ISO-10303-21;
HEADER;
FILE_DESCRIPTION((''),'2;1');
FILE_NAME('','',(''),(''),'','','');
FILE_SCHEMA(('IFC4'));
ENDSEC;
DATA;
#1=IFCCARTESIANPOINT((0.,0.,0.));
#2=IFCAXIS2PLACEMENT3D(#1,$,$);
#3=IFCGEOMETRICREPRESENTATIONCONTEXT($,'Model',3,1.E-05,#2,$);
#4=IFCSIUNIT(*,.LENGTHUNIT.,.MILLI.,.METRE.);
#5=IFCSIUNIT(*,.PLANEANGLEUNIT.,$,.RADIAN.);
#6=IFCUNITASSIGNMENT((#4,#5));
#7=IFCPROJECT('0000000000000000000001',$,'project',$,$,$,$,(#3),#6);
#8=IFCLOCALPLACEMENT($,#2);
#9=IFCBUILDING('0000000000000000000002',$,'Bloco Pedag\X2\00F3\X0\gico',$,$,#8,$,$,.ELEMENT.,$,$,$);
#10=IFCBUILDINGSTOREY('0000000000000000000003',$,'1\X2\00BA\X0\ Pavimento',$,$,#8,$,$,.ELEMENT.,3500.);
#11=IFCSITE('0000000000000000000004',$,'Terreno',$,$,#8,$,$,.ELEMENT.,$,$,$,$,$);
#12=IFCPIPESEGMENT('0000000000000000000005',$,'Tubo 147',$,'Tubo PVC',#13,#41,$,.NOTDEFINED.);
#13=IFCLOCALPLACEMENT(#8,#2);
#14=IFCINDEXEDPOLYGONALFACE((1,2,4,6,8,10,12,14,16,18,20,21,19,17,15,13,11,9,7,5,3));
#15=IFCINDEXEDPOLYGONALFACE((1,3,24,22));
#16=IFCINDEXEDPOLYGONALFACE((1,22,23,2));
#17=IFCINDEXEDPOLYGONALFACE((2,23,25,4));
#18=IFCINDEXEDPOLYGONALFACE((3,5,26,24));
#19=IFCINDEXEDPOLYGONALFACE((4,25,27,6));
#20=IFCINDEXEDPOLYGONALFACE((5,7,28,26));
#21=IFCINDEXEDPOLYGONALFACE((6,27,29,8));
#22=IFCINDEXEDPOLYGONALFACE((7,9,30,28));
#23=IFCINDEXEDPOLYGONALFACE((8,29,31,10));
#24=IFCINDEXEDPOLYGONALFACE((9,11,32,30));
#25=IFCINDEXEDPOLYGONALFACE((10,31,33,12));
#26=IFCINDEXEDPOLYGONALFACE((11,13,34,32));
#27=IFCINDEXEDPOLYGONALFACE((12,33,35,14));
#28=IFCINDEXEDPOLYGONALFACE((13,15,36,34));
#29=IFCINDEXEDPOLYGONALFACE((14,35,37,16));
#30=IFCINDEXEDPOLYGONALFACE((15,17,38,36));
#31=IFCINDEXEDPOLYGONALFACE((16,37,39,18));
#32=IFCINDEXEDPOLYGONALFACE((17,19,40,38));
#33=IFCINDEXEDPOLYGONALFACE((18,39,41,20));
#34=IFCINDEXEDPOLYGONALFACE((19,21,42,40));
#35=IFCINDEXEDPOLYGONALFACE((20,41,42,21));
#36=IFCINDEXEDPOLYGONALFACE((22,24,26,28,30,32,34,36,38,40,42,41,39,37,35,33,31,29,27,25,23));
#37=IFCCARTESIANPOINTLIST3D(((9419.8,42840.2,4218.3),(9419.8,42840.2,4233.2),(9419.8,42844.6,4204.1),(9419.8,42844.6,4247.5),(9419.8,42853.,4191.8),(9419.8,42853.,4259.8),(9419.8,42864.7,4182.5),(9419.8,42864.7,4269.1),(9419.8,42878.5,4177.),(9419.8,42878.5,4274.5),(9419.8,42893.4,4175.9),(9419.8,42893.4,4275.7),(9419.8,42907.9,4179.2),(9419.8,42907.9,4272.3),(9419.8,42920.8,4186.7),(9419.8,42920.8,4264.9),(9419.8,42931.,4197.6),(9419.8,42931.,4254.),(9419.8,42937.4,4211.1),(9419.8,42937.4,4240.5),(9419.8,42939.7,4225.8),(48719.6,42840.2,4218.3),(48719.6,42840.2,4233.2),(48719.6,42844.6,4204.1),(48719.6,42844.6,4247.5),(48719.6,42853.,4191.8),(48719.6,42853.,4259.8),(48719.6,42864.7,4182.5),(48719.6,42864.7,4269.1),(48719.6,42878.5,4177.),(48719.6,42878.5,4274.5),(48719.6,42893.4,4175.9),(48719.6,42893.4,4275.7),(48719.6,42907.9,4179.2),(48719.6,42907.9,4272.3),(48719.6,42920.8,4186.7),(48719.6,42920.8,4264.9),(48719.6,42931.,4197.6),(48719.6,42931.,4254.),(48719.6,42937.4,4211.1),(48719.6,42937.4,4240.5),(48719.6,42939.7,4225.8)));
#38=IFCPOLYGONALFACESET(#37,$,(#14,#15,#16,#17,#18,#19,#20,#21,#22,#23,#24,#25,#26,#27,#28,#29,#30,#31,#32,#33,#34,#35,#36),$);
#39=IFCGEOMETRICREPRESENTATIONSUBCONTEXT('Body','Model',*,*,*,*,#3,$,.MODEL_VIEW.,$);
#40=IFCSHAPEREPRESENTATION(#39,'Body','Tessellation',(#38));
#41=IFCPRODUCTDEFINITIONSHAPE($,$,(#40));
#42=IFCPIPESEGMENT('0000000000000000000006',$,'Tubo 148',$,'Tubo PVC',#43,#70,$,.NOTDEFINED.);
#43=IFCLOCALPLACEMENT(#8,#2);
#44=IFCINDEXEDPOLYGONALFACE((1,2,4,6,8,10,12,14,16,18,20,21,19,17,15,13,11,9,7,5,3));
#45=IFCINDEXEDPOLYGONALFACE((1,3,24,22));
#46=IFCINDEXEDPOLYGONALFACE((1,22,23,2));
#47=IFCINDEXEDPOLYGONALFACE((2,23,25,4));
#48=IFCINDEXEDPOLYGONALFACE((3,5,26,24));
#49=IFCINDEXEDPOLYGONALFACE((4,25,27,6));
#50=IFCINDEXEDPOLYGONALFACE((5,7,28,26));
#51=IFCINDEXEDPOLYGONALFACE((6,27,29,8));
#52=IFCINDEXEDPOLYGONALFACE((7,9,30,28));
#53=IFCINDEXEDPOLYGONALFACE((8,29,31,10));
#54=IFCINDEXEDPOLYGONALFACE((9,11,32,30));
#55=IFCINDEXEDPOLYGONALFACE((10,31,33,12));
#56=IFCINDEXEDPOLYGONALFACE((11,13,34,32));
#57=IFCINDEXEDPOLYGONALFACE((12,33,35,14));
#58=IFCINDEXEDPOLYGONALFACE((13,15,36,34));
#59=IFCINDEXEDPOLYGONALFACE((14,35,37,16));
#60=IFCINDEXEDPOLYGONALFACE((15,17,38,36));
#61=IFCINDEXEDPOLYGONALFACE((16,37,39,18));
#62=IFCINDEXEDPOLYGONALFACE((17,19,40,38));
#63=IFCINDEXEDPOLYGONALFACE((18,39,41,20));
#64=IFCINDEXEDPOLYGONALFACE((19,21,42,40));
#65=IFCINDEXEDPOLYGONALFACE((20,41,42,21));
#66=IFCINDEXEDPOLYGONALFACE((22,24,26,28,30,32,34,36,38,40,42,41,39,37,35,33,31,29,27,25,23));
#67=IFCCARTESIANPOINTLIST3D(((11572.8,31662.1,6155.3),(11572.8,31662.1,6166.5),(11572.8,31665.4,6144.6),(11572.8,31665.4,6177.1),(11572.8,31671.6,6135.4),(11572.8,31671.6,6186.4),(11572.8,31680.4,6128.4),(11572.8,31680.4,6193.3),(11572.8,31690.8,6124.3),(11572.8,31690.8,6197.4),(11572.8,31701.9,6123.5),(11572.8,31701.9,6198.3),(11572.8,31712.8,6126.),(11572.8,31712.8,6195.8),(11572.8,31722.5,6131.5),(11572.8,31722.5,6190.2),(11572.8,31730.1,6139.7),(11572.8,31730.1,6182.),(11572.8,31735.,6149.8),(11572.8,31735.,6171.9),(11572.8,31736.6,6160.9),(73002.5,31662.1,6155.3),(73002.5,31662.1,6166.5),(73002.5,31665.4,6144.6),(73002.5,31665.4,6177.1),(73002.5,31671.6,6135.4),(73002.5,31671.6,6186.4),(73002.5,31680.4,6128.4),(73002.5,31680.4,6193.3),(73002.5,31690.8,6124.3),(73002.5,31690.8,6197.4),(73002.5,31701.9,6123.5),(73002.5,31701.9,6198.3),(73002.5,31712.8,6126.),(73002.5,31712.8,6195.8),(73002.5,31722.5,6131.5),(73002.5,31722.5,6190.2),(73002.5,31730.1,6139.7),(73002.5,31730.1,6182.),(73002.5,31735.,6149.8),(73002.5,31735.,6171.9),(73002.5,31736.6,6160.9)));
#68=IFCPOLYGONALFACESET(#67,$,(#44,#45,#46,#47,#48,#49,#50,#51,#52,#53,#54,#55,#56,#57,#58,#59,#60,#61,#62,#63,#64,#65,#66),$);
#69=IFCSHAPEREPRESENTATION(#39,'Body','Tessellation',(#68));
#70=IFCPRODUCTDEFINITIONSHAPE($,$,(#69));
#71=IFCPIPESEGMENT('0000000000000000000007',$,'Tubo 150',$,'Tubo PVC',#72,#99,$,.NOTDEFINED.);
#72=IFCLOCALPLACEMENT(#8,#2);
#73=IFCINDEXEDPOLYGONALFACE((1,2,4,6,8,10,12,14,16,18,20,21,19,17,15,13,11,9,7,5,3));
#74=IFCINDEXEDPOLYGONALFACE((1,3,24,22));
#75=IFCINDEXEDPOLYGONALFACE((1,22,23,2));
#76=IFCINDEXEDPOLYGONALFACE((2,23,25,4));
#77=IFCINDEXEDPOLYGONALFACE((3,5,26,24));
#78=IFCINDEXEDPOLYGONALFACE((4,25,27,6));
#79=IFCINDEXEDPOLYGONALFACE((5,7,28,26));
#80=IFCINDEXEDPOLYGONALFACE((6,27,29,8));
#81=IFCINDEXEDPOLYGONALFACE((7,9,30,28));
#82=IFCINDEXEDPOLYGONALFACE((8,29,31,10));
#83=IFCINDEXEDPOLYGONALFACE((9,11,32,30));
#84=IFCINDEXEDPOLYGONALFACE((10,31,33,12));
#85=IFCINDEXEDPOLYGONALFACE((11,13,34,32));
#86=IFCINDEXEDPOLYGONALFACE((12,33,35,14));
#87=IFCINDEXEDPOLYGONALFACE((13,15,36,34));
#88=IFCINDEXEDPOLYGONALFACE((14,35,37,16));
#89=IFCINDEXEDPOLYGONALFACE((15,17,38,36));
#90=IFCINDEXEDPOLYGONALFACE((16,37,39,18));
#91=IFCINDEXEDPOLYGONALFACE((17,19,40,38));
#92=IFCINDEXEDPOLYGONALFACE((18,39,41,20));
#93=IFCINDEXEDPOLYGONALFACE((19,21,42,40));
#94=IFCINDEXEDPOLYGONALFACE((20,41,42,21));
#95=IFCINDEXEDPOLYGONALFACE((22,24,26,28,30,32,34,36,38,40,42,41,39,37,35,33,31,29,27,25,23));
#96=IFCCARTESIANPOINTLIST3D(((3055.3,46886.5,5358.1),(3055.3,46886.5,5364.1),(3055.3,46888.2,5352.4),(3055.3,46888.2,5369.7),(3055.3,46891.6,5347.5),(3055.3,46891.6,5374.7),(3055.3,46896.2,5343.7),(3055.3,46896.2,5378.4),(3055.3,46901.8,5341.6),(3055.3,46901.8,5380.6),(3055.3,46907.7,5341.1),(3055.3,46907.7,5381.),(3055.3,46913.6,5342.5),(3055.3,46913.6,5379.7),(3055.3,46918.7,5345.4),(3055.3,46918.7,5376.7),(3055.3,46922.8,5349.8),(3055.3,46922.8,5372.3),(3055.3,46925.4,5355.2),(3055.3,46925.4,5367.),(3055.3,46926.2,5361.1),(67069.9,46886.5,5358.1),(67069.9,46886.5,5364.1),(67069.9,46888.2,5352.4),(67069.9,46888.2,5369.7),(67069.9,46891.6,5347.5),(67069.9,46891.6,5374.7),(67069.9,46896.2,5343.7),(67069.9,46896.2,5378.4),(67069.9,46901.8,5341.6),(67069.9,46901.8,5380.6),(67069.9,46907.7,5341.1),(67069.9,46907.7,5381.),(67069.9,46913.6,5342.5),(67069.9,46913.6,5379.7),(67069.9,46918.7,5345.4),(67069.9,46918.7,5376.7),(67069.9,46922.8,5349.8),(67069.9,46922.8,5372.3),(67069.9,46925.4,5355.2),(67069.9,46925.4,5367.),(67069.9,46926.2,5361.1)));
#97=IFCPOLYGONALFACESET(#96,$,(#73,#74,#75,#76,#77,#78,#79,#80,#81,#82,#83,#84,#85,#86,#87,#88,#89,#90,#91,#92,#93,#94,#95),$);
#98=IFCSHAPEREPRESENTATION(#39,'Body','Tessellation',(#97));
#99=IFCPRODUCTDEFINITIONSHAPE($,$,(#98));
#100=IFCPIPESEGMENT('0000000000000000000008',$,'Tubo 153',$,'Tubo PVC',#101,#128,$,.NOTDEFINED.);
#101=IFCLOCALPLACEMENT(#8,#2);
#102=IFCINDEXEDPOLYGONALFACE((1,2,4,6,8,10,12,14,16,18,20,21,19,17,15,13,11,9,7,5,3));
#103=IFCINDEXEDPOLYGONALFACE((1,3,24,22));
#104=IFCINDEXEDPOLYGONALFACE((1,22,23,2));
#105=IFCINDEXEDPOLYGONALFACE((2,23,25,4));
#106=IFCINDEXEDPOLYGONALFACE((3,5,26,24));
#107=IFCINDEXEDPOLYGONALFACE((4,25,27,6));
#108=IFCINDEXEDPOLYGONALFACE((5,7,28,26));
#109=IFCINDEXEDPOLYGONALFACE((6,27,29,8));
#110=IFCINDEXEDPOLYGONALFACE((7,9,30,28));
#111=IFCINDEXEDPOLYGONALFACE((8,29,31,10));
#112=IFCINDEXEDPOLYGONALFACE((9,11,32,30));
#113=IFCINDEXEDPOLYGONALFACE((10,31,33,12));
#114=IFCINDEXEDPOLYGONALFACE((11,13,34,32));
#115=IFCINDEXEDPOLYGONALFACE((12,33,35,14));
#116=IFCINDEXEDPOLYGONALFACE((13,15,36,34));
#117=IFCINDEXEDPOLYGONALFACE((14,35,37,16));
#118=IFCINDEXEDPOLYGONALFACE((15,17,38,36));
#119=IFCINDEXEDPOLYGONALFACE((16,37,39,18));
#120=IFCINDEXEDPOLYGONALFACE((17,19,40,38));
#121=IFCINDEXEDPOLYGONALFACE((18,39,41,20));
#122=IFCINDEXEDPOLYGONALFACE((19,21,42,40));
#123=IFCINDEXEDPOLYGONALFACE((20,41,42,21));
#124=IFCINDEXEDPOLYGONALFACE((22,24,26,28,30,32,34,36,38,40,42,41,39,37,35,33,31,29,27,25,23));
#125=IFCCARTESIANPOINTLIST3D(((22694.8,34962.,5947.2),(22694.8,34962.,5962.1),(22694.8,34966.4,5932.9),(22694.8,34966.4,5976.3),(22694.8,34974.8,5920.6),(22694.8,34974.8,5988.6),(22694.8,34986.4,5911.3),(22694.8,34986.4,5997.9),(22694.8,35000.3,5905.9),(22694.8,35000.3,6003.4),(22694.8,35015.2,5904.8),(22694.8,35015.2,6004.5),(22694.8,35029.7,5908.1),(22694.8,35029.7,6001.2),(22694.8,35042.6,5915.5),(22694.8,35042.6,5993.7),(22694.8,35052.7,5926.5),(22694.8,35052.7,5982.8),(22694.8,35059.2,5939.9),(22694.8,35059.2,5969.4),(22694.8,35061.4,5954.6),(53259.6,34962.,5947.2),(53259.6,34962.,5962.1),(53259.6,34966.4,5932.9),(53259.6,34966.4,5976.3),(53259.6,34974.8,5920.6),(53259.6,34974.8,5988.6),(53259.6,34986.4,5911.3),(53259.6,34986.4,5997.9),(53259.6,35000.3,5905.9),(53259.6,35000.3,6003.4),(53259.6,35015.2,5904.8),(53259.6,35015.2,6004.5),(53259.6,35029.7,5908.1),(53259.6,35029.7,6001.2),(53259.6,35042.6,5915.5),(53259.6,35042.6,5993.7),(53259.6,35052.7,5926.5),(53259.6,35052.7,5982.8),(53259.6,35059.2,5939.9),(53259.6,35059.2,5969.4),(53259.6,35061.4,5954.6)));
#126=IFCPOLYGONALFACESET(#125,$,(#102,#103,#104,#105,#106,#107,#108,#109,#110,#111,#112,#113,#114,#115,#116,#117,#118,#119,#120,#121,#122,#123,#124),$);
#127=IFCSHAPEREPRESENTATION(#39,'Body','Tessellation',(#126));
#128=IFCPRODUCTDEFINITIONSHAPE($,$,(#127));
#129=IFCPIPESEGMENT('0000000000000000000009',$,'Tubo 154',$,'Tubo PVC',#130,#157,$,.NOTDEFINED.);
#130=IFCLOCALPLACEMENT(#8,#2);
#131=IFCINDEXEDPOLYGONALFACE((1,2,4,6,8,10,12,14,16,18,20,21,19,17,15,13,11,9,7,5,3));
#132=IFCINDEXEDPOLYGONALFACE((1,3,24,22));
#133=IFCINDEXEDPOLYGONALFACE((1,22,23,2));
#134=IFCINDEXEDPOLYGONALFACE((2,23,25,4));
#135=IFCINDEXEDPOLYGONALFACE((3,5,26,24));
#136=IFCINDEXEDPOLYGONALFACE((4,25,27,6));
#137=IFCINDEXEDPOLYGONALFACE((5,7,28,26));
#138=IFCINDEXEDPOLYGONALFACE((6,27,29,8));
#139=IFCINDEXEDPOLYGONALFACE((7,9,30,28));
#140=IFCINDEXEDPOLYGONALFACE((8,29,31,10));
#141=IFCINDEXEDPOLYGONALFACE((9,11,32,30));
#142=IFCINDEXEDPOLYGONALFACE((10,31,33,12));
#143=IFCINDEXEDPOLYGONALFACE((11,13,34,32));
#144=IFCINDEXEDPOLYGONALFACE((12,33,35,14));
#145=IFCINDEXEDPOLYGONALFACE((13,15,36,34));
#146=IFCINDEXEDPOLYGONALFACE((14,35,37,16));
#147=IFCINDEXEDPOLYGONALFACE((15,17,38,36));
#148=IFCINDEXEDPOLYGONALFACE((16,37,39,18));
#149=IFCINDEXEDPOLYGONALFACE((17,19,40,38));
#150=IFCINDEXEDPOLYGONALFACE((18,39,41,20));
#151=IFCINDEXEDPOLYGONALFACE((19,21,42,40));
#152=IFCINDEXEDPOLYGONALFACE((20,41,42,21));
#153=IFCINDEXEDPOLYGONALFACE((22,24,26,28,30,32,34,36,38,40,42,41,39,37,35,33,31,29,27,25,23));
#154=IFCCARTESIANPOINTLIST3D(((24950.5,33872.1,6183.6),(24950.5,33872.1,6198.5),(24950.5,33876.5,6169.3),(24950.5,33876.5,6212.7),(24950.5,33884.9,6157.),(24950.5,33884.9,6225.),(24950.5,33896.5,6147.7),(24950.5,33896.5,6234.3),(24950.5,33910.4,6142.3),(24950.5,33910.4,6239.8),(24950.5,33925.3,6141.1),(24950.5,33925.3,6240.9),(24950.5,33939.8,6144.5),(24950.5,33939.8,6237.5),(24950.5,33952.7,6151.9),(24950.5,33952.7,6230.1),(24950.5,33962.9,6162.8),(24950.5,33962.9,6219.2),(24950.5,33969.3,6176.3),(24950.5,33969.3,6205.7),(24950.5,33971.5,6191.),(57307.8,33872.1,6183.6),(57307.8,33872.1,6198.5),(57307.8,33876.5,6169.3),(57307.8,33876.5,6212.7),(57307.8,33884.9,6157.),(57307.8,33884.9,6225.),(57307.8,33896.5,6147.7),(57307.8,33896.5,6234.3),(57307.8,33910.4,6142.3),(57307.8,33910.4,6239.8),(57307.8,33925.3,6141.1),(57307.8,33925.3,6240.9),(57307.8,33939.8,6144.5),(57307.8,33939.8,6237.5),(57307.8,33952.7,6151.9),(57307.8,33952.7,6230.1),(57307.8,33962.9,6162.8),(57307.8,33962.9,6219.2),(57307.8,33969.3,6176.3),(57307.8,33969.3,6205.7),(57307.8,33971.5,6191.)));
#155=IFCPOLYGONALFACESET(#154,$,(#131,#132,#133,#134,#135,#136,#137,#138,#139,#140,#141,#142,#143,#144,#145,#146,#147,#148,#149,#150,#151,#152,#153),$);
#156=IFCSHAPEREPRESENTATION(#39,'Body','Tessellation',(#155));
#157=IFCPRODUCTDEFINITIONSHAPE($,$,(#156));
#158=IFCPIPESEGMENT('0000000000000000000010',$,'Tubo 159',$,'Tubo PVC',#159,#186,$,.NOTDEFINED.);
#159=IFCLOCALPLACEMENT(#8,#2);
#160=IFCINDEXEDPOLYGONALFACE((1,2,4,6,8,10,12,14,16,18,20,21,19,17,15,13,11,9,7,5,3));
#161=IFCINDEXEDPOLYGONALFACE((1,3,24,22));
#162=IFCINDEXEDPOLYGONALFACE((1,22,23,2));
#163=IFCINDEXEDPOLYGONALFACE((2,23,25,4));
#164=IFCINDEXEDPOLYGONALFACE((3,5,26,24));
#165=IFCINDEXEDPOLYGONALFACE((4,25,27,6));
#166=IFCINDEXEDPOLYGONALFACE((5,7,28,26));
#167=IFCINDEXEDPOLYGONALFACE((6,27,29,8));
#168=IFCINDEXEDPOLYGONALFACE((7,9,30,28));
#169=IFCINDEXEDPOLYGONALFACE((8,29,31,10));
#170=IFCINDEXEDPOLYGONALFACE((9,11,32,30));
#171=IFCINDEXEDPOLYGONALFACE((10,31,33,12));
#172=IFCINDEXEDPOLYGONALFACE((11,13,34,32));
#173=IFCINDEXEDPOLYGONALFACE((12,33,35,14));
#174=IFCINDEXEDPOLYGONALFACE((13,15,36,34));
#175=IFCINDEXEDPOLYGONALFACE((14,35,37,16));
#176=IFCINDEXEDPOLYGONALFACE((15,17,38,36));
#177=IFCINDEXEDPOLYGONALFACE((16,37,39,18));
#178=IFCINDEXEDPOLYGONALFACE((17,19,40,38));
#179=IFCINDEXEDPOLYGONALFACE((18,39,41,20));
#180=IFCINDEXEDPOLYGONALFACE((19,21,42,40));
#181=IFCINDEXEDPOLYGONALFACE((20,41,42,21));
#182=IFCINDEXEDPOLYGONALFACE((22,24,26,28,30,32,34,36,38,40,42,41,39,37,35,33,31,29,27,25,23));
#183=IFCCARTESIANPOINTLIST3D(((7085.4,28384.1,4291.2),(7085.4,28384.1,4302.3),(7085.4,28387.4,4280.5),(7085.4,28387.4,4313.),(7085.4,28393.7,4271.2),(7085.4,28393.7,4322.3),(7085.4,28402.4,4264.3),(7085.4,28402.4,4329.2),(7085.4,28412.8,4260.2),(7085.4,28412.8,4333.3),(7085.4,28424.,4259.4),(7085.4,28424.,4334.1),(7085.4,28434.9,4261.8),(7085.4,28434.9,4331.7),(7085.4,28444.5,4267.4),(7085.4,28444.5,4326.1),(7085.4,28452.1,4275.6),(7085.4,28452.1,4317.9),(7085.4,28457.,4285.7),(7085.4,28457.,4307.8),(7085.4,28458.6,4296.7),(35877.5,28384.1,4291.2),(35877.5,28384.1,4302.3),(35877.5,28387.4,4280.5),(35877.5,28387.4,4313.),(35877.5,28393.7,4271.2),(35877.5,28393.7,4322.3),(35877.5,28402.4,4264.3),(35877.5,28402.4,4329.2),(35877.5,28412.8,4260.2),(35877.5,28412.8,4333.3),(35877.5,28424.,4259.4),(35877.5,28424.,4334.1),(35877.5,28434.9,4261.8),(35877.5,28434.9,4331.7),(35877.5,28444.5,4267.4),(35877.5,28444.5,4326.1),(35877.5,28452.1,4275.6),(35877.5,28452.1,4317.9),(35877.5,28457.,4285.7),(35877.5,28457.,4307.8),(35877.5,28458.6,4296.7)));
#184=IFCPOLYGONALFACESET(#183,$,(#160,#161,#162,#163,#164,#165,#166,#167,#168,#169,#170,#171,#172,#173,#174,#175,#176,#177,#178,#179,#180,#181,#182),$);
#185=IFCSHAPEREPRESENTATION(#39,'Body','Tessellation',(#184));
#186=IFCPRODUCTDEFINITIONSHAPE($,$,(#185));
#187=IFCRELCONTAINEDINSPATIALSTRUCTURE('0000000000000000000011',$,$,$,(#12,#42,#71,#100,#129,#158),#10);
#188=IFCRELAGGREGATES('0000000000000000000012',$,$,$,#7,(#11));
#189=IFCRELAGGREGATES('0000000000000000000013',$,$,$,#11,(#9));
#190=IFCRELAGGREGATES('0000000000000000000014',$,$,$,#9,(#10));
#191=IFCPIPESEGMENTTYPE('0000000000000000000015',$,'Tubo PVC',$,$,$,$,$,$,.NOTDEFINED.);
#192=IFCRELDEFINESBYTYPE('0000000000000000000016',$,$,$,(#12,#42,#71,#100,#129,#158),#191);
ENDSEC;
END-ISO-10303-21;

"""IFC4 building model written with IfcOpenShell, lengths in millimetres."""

from ifc_helpers import new_model, si_unit, frame, origin, origin_2d, place, context, subcontext, project, spatial, circle, extrude, type_object, element, save


model = new_model("IFC4")

# Units and contexts
model_context = context("Model", 3, precision=1e-05, world=origin())
body_context = subcontext(model_context, "Body", "Model", "MODEL_VIEW")
ifc_project = project(units=[si_unit("LENGTHUNIT", "METRE", prefix="MILLI"), si_unit("PLANEANGLEUNIT", "RADIAN")], contexts=[model_context])

# Site, building, storey
placement = place(None, origin())
site = spatial("IfcSite", under=ifc_project, at=placement, Name="Terreno", CompositionType="ELEMENT")
building = spatial("IfcBuilding", under=site, at=placement, Name="Bloco Pedagógico", CompositionType="ELEMENT")
storey = spatial("IfcBuildingStorey", under=building, at=placement, Name="1º Pavimento", CompositionType="ELEMENT", Elevation=3500.0)

# Pipe segments
pipe_segment_type = type_object("IfcPipeSegmentType", Name="Tubo PVC", PredefinedType="NOTDEFINED")
pipe_segment_1_placement = place(None, frame((9419.8, 42889.7, 4225.8), z_axis=(1.0, 0.0, 0.0), x_axis=(0.0, 1.0, 0.0)))
element("IfcPipeSegment", 1, at=pipe_segment_1_placement, inside=storey, type_object=pipe_segment_type, Name="Tubo 147", ObjectType="Tubo PVC", PredefinedType="NOTDEFINED", context=body_context, shape_type="SweptSolid", body=[
    extrude(circle(Radius=50.0, at=origin_2d()), None, (0.0, 0.0, 1.0), 39299.8),
])
pipe_segment_2_placement = place(None, frame((11572.8, 31699.1, 6160.9), z_axis=(1.0, 0.0, 0.0), x_axis=(0.0, 1.0, 0.0)))
element("IfcPipeSegment", 2, at=pipe_segment_2_placement, inside=storey, type_object=pipe_segment_type, Name="Tubo 148", ObjectType="Tubo PVC", PredefinedType="NOTDEFINED", context=body_context, shape_type="SweptSolid", body=[
    extrude(circle(Radius=37.5, at=origin_2d()), None, (0.0, 0.0, 1.0), 61429.7),
])
pipe_segment_3_placement = place(None, frame((3055.3, 46906.2, 5361.1), z_axis=(1.0, 0.0, 0.0), x_axis=(0.0, 1.0, 0.0)))
element("IfcPipeSegment", 3, at=pipe_segment_3_placement, inside=storey, type_object=pipe_segment_type, Name="Tubo 150", ObjectType="Tubo PVC", PredefinedType="NOTDEFINED", context=body_context, shape_type="SweptSolid", body=[
    extrude(circle(Radius=20.0, at=origin_2d()), None, (0.0, 0.0, 1.0), 64014.5),
])
pipe_segment_4_placement = place(None, frame((22694.8, 35011.4, 5954.6), z_axis=(1.0, 0.0, 0.0), x_axis=(0.0, 1.0, 0.0)))
element("IfcPipeSegment", 4, at=pipe_segment_4_placement, inside=storey, type_object=pipe_segment_type, Name="Tubo 153", ObjectType="Tubo PVC", PredefinedType="NOTDEFINED", context=body_context, shape_type="SweptSolid", body=[
    extrude(circle(Radius=50.0, at=origin_2d()), None, (0.0, 0.0, 1.0), 30564.7),
])
pipe_segment_5_placement = place(None, frame((24950.5, 33921.5, 6191.0), z_axis=(1.0, 0.0, 0.0), x_axis=(0.0, 1.0, 0.0)))
element("IfcPipeSegment", 5, at=pipe_segment_5_placement, inside=storey, type_object=pipe_segment_type, Name="Tubo 154", ObjectType="Tubo PVC", PredefinedType="NOTDEFINED", context=body_context, shape_type="SweptSolid", body=[
    extrude(circle(Radius=50.0, at=origin_2d()), None, (0.0, 0.0, 1.0), 32357.3),
])
pipe_segment_6_placement = place(None, frame((7085.4, 28421.1, 4296.7), z_axis=(1.0, 0.0, 0.0), x_axis=(0.0, 1.0, 0.0)))
element("IfcPipeSegment", 6, at=pipe_segment_6_placement, inside=storey, type_object=pipe_segment_type, Name="Tubo 159", ObjectType="Tubo PVC", PredefinedType="NOTDEFINED", context=body_context, shape_type="SweptSolid", body=[
    extrude(circle(Radius=37.5, at=origin_2d()), None, (0.0, 0.0, 1.0), 28792.1),
])

save(model, "model.ifc")
